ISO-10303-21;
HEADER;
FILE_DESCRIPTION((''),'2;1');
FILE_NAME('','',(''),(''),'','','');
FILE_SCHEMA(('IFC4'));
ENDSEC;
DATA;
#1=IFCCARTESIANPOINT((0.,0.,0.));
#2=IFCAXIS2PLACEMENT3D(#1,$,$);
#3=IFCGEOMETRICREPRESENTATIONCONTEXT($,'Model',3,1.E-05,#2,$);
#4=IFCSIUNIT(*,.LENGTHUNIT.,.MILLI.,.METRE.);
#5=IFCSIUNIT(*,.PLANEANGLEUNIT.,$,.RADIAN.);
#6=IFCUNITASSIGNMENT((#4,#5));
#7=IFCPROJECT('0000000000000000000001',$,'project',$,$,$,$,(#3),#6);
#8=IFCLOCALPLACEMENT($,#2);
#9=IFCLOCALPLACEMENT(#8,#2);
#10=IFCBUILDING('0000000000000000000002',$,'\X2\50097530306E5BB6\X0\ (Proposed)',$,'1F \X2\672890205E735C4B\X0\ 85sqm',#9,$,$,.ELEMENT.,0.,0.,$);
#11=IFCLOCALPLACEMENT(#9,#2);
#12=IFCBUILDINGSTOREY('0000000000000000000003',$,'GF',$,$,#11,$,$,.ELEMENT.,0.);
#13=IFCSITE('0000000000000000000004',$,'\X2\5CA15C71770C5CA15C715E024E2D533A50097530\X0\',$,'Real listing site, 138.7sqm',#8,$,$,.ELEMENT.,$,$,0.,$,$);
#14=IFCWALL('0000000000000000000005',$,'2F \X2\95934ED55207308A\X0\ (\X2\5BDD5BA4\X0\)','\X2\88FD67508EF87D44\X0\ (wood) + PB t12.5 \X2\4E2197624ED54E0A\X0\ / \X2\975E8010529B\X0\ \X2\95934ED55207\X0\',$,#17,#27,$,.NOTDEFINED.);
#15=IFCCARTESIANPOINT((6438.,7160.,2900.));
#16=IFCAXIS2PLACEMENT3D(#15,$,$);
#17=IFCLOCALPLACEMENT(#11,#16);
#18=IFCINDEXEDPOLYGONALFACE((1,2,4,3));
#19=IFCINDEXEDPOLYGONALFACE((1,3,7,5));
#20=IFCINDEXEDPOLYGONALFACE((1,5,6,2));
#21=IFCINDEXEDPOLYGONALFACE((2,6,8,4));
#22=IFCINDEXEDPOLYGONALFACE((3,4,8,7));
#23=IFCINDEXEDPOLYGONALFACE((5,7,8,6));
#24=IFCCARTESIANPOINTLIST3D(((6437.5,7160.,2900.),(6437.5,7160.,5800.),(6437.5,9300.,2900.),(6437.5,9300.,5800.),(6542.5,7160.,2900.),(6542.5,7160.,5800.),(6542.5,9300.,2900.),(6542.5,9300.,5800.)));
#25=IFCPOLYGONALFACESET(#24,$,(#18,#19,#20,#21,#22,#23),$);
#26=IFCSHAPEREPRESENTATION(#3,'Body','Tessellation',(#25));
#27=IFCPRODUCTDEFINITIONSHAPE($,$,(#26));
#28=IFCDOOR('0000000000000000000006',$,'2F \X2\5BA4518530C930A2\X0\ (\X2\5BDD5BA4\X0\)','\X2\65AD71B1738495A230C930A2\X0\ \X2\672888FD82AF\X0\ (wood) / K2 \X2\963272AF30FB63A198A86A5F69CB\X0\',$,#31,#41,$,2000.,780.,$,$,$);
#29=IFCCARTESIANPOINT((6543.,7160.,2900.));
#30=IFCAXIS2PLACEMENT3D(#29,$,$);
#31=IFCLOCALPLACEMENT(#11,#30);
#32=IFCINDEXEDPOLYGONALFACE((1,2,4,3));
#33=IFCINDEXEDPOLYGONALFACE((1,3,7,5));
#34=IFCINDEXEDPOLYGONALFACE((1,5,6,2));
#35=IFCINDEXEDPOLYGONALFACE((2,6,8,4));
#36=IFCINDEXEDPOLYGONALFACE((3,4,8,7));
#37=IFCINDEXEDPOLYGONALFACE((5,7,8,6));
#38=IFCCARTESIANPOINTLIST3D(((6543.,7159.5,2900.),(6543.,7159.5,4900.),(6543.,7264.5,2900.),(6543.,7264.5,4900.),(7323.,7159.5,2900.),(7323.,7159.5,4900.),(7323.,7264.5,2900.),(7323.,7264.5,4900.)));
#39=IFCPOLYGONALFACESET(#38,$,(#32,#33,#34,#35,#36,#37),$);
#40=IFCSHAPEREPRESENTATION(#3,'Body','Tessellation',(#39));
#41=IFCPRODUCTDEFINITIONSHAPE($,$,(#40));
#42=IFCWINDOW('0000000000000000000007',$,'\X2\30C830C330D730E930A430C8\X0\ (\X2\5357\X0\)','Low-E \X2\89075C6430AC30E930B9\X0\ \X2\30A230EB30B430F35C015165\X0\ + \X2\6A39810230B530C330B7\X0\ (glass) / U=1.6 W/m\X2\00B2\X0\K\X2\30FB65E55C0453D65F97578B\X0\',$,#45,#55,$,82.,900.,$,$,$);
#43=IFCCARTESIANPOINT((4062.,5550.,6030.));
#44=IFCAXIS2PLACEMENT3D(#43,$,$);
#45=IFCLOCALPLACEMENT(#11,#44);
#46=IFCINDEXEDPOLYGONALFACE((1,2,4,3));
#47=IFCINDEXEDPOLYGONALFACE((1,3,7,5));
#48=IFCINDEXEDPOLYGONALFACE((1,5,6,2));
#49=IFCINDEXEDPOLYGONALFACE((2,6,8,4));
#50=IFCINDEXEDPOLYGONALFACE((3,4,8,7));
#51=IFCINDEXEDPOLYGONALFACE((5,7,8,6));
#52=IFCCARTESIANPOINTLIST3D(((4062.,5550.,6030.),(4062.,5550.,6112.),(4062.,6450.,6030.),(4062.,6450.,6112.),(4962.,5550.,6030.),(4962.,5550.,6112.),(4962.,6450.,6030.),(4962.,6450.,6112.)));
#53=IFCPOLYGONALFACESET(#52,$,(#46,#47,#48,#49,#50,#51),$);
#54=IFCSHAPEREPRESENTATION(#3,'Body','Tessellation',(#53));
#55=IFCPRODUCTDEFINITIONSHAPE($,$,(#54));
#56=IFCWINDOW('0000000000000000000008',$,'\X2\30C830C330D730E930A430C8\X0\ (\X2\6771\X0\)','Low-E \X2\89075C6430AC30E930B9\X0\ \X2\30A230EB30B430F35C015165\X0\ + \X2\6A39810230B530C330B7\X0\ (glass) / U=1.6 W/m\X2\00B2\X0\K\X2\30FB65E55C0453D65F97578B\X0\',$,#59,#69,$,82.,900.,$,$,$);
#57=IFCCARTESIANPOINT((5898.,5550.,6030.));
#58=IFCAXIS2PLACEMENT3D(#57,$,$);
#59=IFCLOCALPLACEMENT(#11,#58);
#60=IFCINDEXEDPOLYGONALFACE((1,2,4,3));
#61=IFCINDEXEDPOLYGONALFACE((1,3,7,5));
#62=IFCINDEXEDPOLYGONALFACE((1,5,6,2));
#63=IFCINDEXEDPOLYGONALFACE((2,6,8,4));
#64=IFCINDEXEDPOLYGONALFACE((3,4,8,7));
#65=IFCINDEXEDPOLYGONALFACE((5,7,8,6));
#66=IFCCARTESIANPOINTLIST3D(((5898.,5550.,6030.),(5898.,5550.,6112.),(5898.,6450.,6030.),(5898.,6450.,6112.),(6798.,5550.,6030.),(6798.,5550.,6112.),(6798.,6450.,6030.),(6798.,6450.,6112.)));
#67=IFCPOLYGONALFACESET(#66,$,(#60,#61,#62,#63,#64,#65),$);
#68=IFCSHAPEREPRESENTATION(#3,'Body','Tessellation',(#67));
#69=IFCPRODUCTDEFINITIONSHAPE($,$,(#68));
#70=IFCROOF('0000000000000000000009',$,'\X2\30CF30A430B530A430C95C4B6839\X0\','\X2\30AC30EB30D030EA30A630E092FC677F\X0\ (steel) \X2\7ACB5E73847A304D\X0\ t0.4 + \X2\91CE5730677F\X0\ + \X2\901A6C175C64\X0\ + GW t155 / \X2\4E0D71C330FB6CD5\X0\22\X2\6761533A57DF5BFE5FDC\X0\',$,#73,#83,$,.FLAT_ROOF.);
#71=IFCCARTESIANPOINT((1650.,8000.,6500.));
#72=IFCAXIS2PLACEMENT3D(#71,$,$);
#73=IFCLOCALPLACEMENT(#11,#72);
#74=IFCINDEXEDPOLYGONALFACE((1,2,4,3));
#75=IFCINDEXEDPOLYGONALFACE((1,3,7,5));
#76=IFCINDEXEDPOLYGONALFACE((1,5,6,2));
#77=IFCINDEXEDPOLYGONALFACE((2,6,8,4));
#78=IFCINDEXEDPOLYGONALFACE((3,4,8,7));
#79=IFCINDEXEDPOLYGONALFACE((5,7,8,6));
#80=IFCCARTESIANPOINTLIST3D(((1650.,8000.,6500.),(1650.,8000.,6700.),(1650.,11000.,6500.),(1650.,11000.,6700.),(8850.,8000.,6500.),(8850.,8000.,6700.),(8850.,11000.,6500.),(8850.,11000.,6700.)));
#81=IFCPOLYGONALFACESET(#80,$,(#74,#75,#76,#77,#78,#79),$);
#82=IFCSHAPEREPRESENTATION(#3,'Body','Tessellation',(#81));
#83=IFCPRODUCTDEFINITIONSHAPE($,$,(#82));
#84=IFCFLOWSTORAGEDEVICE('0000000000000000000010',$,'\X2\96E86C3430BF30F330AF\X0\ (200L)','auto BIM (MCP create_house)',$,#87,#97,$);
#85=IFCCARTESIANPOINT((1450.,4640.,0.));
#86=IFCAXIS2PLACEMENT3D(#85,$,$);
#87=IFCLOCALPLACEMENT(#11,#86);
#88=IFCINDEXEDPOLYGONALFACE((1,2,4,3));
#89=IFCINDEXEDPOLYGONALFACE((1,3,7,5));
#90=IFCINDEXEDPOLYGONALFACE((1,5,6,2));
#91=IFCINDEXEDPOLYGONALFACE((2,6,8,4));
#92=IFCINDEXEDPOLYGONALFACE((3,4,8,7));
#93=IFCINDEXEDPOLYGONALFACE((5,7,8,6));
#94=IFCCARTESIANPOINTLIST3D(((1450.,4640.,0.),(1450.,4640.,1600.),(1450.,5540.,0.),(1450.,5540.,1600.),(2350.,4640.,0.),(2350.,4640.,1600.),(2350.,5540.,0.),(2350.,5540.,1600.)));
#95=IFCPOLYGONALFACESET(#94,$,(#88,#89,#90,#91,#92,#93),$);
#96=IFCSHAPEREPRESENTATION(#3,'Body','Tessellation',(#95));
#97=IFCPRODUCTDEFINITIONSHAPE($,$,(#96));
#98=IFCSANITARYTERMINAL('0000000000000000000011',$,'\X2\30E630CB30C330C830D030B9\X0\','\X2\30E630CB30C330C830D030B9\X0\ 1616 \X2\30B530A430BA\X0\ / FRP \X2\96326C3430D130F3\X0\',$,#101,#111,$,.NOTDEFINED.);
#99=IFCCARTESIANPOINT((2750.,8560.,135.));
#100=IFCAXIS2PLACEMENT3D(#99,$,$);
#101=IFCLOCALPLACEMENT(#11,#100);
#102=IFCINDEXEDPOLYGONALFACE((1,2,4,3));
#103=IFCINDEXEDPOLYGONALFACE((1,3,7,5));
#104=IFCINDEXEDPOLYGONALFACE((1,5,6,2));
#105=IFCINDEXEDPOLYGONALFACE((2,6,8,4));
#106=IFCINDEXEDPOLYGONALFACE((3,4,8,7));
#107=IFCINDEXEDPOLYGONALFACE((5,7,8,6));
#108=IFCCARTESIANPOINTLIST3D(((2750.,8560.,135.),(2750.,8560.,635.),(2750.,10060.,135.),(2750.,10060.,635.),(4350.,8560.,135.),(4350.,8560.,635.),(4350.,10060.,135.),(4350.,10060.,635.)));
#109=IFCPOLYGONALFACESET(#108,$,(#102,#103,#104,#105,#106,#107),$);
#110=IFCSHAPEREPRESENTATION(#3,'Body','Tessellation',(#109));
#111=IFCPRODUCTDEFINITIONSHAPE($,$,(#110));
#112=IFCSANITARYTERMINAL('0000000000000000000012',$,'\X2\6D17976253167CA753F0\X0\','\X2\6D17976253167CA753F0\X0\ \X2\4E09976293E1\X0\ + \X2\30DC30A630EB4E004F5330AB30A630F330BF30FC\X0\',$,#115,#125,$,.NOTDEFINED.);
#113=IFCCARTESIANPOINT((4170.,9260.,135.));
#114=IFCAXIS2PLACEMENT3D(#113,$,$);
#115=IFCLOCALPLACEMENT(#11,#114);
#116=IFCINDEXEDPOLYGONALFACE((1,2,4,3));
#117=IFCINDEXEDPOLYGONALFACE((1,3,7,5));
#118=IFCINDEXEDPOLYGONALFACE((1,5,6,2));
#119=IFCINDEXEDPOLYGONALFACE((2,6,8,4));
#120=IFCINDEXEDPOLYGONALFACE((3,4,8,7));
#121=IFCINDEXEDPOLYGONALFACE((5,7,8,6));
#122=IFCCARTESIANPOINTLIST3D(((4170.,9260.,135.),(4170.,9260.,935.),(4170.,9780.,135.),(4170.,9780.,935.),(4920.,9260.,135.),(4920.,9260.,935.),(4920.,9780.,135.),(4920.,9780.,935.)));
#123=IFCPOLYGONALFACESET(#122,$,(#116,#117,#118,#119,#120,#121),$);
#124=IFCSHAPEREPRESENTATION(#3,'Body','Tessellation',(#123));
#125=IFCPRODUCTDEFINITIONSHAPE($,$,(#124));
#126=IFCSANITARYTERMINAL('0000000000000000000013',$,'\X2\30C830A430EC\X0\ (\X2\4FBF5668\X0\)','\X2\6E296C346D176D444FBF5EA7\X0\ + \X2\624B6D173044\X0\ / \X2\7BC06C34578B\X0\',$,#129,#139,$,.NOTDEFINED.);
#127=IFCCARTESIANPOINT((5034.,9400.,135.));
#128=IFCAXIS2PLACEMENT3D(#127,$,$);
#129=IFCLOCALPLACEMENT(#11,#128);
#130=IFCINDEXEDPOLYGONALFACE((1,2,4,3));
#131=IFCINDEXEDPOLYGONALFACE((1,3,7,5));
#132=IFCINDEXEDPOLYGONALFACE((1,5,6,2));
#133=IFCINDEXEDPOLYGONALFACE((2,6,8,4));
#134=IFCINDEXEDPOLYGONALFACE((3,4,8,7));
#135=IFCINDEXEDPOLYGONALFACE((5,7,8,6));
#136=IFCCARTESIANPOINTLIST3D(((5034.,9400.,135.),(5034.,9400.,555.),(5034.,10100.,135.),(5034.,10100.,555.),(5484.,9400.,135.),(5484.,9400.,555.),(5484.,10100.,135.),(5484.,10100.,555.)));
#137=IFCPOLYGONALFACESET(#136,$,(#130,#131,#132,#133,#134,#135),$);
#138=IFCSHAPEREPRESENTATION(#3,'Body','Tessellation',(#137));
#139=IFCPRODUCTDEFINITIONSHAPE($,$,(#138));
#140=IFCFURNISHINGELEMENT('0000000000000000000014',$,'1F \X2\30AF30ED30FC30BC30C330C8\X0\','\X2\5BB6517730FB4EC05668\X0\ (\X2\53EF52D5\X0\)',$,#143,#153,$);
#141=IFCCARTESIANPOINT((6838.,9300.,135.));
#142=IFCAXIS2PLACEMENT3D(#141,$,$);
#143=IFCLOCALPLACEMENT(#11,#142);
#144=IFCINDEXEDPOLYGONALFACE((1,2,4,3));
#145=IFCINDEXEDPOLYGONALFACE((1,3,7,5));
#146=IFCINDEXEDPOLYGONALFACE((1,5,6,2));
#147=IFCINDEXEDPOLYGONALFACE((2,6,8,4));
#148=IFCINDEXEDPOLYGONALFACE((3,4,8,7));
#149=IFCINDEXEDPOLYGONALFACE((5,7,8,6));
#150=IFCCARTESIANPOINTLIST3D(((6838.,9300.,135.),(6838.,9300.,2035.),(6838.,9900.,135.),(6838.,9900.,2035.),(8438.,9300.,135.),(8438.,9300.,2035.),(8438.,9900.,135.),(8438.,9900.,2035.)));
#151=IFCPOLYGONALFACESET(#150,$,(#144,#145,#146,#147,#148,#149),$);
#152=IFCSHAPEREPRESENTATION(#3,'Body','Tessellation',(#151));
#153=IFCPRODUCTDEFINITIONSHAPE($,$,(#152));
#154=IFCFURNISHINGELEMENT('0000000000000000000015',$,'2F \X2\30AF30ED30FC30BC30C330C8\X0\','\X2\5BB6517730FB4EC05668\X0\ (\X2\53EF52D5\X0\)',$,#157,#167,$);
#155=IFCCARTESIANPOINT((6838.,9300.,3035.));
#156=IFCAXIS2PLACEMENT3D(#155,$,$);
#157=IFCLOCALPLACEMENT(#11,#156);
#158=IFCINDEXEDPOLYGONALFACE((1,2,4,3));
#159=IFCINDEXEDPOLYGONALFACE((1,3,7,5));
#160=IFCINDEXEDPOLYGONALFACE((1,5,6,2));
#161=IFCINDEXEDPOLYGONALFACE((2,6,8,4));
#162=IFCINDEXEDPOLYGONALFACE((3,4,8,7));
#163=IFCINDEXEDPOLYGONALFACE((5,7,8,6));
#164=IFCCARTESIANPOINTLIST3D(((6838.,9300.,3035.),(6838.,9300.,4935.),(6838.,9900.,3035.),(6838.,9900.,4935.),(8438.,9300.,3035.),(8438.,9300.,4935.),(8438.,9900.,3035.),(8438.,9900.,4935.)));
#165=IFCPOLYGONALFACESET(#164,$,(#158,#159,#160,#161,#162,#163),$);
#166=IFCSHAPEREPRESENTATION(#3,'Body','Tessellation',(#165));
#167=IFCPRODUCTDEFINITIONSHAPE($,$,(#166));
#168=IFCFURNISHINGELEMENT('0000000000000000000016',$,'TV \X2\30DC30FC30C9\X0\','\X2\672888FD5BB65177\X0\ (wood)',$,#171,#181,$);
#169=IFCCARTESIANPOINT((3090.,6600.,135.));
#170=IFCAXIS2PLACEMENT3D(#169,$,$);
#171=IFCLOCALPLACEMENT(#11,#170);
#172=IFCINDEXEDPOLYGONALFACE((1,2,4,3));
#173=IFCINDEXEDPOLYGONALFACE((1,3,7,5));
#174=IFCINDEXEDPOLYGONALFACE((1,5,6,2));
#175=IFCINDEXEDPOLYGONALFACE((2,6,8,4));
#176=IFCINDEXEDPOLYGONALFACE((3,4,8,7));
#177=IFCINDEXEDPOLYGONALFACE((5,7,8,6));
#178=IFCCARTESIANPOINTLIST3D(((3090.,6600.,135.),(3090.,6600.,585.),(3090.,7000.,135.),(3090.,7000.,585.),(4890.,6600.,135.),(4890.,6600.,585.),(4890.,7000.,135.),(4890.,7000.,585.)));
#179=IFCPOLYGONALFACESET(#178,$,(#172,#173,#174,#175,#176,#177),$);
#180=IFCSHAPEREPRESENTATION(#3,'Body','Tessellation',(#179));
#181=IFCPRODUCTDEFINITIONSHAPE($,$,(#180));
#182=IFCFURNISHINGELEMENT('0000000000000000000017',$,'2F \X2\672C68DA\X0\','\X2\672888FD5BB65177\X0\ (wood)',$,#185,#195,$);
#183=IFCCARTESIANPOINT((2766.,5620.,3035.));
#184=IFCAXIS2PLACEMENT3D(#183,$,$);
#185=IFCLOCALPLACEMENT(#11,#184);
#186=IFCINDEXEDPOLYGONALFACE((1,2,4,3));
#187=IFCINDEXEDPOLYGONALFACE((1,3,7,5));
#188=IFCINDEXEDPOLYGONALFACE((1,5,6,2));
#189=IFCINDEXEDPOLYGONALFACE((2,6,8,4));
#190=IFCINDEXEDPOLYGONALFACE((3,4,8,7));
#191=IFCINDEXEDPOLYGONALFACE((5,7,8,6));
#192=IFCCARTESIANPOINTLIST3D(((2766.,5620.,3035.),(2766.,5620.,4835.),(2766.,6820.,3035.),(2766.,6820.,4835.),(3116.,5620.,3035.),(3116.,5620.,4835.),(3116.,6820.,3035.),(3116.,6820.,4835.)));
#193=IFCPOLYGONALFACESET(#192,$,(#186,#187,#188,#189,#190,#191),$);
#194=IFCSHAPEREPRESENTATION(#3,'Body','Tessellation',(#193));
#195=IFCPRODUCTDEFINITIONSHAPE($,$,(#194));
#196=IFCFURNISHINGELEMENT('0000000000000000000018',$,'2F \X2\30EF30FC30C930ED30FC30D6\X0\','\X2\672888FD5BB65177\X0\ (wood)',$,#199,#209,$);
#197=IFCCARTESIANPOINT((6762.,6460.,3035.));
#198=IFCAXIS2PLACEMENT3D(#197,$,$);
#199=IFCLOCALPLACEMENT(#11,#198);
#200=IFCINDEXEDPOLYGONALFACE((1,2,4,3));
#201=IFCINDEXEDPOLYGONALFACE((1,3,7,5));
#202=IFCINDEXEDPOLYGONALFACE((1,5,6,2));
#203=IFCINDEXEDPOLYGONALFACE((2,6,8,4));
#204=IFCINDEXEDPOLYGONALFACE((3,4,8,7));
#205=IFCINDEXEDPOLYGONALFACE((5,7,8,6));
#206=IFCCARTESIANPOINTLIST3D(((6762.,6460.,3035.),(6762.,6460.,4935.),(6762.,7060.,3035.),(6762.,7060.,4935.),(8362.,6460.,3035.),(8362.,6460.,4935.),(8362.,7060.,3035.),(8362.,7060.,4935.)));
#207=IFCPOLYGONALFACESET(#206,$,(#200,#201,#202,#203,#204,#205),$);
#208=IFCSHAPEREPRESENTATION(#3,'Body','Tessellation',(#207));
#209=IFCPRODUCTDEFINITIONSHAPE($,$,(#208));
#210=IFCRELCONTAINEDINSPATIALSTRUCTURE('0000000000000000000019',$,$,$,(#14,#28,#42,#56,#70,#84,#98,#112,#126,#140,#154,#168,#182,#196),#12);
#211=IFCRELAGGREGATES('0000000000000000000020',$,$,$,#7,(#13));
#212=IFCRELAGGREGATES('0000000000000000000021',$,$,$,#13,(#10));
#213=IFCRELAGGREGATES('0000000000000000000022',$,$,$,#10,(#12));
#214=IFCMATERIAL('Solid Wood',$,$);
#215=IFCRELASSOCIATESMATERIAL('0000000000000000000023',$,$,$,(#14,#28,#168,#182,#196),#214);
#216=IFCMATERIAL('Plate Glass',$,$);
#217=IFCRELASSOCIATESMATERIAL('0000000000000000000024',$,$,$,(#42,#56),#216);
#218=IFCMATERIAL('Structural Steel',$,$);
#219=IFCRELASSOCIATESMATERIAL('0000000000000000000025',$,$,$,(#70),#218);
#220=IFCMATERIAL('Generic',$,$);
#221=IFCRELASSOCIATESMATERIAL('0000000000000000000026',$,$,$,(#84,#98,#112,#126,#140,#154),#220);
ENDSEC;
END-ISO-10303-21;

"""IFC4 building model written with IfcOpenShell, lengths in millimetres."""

from ifc_helpers import new_model, si_unit, frame, frame_2d, origin, place, context, project, spatial, rectangle, extrude, material, element, save


model = new_model("IFC4")

# Units and contexts
model_context = context("Model", 3, precision=1e-05, world=origin())
ifc_project = project(units=[si_unit("LENGTHUNIT", "METRE", prefix="MILLI"), si_unit("PLANEANGLEUNIT", "RADIAN")], contexts=[model_context])

# Site, building, storey
site_placement = place(None, origin())
site = spatial("IfcSite", under=ifc_project, at=site_placement, Name="岡山県岡山市中区倉田", ObjectType="Real listing site, 138.7sqm", CompositionType="ELEMENT", RefElevation=0.0)
building_placement = place(site_placement, origin())
building = spatial("IfcBuilding", under=site, at=building_placement, Name="倉田の家 (Proposed)", ObjectType="1F 木造平屋 85sqm", CompositionType="ELEMENT", ElevationOfRefHeight=0.0, ElevationOfTerrain=0.0)
storey_placement = place(building_placement, origin())
storey = spatial("IfcBuildingStorey", under=building, at=storey_placement, Name="GF", CompositionType="ELEMENT", Elevation=0.0)

# Shared definitions
ifc_material_1 = material(Name="Solid Wood")
ifc_material_2 = material(Name="Plate Glass")

# Wall
wall_1_placement = place(storey_placement, frame((6438.0, 7160.0, 2900.0)))
element("IfcWall", 1, at=wall_1_placement, inside=storey, material=ifc_material_1, Name="2F 間仕切り (寝室)", Description="製材軸組 (wood) + PB t12.5 両面仕上 / 非耐力 間仕切", PredefinedType="NOTDEFINED", context=model_context, shape_type="SweptSolid", body=[
    extrude(rectangle(XDim=105.0, YDim=2140.0, at=frame_2d((52.0, 1070.0))), frame((6438.0, 7160.0, 2900.0)), (0.0, 0.0, 1.0), 2900.0),
])

# Door
door_1_placement = place(storey_placement, frame((6543.0, 7160.0, 2900.0)))
element("IfcDoor", 2, at=door_1_placement, inside=storey, material=ifc_material_1, Name="2F 室内ドア (寝室)", Description="断熱玄関ドア 木製芯 (wood) / K2 防犯・採風機構", OverallHeight=2000.0, OverallWidth=780.0, context=model_context, shape_type="SweptSolid", body=[
    extrude(rectangle(XDim=780.0, YDim=105.0, at=frame_2d((390.0, 52.0))), frame((6543.0, 7160.0, 2900.0)), (0.0, 0.0, 1.0), 2000.0),
])

# Windows
window_1_placement = place(storey_placement, frame((4062.0, 5550.0, 6030.0)))
element("IfcWindow", 3, at=window_1_placement, inside=storey, material=ifc_material_2, Name="トップライト (南)", Description="Low-E 複層ガラス アルゴン封入 + 樹脂サッシ (glass) / U=1.6 W/m²K・日射取得型", OverallHeight=82.0, OverallWidth=900.0, context=model_context, shape_type="SweptSolid", body=[
    extrude(rectangle(XDim=900.0, YDim=900.0, at=frame_2d((450.0, 450.0))), frame((4062.0, 5550.0, 6030.0)), (0.0, 0.0, 1.0), 82.0),
])
window_2_placement = place(storey_placement, frame((5898.0, 5550.0, 6030.0)))
element("IfcWindow", 4, at=window_2_placement, inside=storey, material=ifc_material_2, Name="トップライト (東)", Description="Low-E 複層ガラス アルゴン封入 + 樹脂サッシ (glass) / U=1.6 W/m²K・日射取得型", OverallHeight=82.0, OverallWidth=900.0, context=model_context, shape_type="SweptSolid", body=[
    extrude(rectangle(XDim=900.0, YDim=900.0, at=frame_2d((450.0, 450.0))), frame((5898.0, 5550.0, 6030.0)), (0.0, 0.0, 1.0), 82.0),
])

# Roof
ifc_material_3 = material(Name="Structural Steel")
roof_placement = place(storey_placement, frame((1650.0, 8000.0, 6500.0)))
element("IfcRoof", 5, at=roof_placement, inside=storey, material=ifc_material_3, Name="ハイサイド屋根", Description="ガルバリウム鋼板 (steel) 立平葺き t0.4 + 野地板 + 通気層 + GW t155 / 不燃・法22条区域対応", PredefinedType="FLAT_ROOF", context=model_context, shape_type="SweptSolid", body=[
    extrude(rectangle(XDim=7200.0, YDim=3000.0, at=frame_2d((3600.0, 1500.0))), frame((1650.0, 8000.0, 6500.0)), (0.0, 0.0, 1.0), 200.0),
])

# Flow storage device
ifc_material_4 = material(Name="Generic")
flow_storage_device_placement = place(storey_placement, frame((1450.0, 4640.0, 0.0)))
element("IfcFlowStorageDevice", 6, at=flow_storage_device_placement, inside=storey, material=ifc_material_4, Name="雨水タンク (200L)", Description="auto BIM (MCP create_house)", context=model_context, shape_type="SweptSolid", body=[
    extrude(rectangle(XDim=900.0, YDim=900.0, at=frame_2d((450.0, 450.0))), frame((1450.0, 4640.0, 0.0)), (0.0, 0.0, 1.0), 1600.0),
])

# Sanitary terminals
sanitary_terminal_1_placement = place(storey_placement, frame((2750.0, 8560.0, 135.0)))
element("IfcSanitaryTerminal", 7, at=sanitary_terminal_1_placement, inside=storey, material=ifc_material_4, Name="ユニットバス", Description="ユニットバス 1616 サイズ / FRP 防水パン", PredefinedType="NOTDEFINED", context=model_context, shape_type="SweptSolid", body=[
    extrude(rectangle(XDim=1600.0, YDim=1500.0, at=frame_2d((800.0, 750.0))), frame((2750.0, 8560.0, 135.0)), (0.0, 0.0, 1.0), 500.0),
])
sanitary_terminal_2_placement = place(storey_placement, frame((4170.0, 9260.0, 135.0)))
element("IfcSanitaryTerminal", 8, at=sanitary_terminal_2_placement, inside=storey, material=ifc_material_4, Name="洗面化粧台", Description="洗面化粧台 三面鏡 + ボウル一体カウンター", PredefinedType="NOTDEFINED", context=model_context, shape_type="SweptSolid", body=[
    extrude(rectangle(XDim=750.0, YDim=520.0, at=frame_2d((375.0, 260.0))), frame((4170.0, 9260.0, 135.0)), (0.0, 0.0, 1.0), 800.0),
])
sanitary_terminal_3_placement = place(storey_placement, frame((5034.0, 9400.0, 135.0)))
element("IfcSanitaryTerminal", 9, at=sanitary_terminal_3_placement, inside=storey, material=ifc_material_4, Name="トイレ (便器)", Description="温水洗浄便座 + 手洗い / 節水型", PredefinedType="NOTDEFINED", context=model_context, shape_type="SweptSolid", body=[
    extrude(rectangle(XDim=450.0, YDim=700.0, at=frame_2d((225.0, 350.0))), frame((5034.0, 9400.0, 135.0)), (0.0, 0.0, 1.0), 420.0),
])

# Furnishing elements
furnishing_1_placement = place(storey_placement, frame((6838.0, 9300.0, 135.0)))
element("IfcFurnishingElement", 10, at=furnishing_1_placement, inside=storey, material=ifc_material_4, Name="1F クローゼット", Description="家具・什器 (可動)", context=model_context, shape_type="SweptSolid", body=[
    extrude(rectangle(XDim=1600.0, YDim=600.0, at=frame_2d((800.0, 300.0))), frame((6838.0, 9300.0, 135.0)), (0.0, 0.0, 1.0), 1900.0),
])
furnishing_2_placement = place(storey_placement, frame((6838.0, 9300.0, 3035.0)))
element("IfcFurnishingElement", 11, at=furnishing_2_placement, inside=storey, material=ifc_material_4, Name="2F クローゼット", Description="家具・什器 (可動)", context=model_context, shape_type="SweptSolid", body=[
    extrude(rectangle(XDim=1600.0, YDim=600.0, at=frame_2d((800.0, 300.0))), frame((6838.0, 9300.0, 3035.0)), (0.0, 0.0, 1.0), 1900.0),
])
furnishing_3_placement = place(storey_placement, frame((3090.0, 6600.0, 135.0)))
element("IfcFurnishingElement", 12, at=furnishing_3_placement, inside=storey, material=ifc_material_1, Name="TV ボード", Description="木製家具 (wood)", context=model_context, shape_type="SweptSolid", body=[
    extrude(rectangle(XDim=1800.0, YDim=400.0, at=frame_2d((900.0, 200.0))), frame((3090.0, 6600.0, 135.0)), (0.0, 0.0, 1.0), 450.0),
])
furnishing_4_placement = place(storey_placement, frame((2766.0, 5620.0, 3035.0)))
element("IfcFurnishingElement", 13, at=furnishing_4_placement, inside=storey, material=ifc_material_1, Name="2F 本棚", Description="木製家具 (wood)", context=model_context, shape_type="SweptSolid", body=[
    extrude(rectangle(XDim=350.0, YDim=1200.0, at=frame_2d((175.0, 600.0))), frame((2766.0, 5620.0, 3035.0)), (0.0, 0.0, 1.0), 1800.0),
])
furnishing_5_placement = place(storey_placement, frame((6762.0, 6460.0, 3035.0)))
element("IfcFurnishingElement", 14, at=furnishing_5_placement, inside=storey, material=ifc_material_1, Name="2F ワードローブ", Description="木製家具 (wood)", context=model_context, shape_type="SweptSolid", body=[
    extrude(rectangle(XDim=1600.0, YDim=600.0, at=frame_2d((800.0, 300.0))), frame((6762.0, 6460.0, 3035.0)), (0.0, 0.0, 1.0), 1900.0),
])

save(model, "model.ifc")
